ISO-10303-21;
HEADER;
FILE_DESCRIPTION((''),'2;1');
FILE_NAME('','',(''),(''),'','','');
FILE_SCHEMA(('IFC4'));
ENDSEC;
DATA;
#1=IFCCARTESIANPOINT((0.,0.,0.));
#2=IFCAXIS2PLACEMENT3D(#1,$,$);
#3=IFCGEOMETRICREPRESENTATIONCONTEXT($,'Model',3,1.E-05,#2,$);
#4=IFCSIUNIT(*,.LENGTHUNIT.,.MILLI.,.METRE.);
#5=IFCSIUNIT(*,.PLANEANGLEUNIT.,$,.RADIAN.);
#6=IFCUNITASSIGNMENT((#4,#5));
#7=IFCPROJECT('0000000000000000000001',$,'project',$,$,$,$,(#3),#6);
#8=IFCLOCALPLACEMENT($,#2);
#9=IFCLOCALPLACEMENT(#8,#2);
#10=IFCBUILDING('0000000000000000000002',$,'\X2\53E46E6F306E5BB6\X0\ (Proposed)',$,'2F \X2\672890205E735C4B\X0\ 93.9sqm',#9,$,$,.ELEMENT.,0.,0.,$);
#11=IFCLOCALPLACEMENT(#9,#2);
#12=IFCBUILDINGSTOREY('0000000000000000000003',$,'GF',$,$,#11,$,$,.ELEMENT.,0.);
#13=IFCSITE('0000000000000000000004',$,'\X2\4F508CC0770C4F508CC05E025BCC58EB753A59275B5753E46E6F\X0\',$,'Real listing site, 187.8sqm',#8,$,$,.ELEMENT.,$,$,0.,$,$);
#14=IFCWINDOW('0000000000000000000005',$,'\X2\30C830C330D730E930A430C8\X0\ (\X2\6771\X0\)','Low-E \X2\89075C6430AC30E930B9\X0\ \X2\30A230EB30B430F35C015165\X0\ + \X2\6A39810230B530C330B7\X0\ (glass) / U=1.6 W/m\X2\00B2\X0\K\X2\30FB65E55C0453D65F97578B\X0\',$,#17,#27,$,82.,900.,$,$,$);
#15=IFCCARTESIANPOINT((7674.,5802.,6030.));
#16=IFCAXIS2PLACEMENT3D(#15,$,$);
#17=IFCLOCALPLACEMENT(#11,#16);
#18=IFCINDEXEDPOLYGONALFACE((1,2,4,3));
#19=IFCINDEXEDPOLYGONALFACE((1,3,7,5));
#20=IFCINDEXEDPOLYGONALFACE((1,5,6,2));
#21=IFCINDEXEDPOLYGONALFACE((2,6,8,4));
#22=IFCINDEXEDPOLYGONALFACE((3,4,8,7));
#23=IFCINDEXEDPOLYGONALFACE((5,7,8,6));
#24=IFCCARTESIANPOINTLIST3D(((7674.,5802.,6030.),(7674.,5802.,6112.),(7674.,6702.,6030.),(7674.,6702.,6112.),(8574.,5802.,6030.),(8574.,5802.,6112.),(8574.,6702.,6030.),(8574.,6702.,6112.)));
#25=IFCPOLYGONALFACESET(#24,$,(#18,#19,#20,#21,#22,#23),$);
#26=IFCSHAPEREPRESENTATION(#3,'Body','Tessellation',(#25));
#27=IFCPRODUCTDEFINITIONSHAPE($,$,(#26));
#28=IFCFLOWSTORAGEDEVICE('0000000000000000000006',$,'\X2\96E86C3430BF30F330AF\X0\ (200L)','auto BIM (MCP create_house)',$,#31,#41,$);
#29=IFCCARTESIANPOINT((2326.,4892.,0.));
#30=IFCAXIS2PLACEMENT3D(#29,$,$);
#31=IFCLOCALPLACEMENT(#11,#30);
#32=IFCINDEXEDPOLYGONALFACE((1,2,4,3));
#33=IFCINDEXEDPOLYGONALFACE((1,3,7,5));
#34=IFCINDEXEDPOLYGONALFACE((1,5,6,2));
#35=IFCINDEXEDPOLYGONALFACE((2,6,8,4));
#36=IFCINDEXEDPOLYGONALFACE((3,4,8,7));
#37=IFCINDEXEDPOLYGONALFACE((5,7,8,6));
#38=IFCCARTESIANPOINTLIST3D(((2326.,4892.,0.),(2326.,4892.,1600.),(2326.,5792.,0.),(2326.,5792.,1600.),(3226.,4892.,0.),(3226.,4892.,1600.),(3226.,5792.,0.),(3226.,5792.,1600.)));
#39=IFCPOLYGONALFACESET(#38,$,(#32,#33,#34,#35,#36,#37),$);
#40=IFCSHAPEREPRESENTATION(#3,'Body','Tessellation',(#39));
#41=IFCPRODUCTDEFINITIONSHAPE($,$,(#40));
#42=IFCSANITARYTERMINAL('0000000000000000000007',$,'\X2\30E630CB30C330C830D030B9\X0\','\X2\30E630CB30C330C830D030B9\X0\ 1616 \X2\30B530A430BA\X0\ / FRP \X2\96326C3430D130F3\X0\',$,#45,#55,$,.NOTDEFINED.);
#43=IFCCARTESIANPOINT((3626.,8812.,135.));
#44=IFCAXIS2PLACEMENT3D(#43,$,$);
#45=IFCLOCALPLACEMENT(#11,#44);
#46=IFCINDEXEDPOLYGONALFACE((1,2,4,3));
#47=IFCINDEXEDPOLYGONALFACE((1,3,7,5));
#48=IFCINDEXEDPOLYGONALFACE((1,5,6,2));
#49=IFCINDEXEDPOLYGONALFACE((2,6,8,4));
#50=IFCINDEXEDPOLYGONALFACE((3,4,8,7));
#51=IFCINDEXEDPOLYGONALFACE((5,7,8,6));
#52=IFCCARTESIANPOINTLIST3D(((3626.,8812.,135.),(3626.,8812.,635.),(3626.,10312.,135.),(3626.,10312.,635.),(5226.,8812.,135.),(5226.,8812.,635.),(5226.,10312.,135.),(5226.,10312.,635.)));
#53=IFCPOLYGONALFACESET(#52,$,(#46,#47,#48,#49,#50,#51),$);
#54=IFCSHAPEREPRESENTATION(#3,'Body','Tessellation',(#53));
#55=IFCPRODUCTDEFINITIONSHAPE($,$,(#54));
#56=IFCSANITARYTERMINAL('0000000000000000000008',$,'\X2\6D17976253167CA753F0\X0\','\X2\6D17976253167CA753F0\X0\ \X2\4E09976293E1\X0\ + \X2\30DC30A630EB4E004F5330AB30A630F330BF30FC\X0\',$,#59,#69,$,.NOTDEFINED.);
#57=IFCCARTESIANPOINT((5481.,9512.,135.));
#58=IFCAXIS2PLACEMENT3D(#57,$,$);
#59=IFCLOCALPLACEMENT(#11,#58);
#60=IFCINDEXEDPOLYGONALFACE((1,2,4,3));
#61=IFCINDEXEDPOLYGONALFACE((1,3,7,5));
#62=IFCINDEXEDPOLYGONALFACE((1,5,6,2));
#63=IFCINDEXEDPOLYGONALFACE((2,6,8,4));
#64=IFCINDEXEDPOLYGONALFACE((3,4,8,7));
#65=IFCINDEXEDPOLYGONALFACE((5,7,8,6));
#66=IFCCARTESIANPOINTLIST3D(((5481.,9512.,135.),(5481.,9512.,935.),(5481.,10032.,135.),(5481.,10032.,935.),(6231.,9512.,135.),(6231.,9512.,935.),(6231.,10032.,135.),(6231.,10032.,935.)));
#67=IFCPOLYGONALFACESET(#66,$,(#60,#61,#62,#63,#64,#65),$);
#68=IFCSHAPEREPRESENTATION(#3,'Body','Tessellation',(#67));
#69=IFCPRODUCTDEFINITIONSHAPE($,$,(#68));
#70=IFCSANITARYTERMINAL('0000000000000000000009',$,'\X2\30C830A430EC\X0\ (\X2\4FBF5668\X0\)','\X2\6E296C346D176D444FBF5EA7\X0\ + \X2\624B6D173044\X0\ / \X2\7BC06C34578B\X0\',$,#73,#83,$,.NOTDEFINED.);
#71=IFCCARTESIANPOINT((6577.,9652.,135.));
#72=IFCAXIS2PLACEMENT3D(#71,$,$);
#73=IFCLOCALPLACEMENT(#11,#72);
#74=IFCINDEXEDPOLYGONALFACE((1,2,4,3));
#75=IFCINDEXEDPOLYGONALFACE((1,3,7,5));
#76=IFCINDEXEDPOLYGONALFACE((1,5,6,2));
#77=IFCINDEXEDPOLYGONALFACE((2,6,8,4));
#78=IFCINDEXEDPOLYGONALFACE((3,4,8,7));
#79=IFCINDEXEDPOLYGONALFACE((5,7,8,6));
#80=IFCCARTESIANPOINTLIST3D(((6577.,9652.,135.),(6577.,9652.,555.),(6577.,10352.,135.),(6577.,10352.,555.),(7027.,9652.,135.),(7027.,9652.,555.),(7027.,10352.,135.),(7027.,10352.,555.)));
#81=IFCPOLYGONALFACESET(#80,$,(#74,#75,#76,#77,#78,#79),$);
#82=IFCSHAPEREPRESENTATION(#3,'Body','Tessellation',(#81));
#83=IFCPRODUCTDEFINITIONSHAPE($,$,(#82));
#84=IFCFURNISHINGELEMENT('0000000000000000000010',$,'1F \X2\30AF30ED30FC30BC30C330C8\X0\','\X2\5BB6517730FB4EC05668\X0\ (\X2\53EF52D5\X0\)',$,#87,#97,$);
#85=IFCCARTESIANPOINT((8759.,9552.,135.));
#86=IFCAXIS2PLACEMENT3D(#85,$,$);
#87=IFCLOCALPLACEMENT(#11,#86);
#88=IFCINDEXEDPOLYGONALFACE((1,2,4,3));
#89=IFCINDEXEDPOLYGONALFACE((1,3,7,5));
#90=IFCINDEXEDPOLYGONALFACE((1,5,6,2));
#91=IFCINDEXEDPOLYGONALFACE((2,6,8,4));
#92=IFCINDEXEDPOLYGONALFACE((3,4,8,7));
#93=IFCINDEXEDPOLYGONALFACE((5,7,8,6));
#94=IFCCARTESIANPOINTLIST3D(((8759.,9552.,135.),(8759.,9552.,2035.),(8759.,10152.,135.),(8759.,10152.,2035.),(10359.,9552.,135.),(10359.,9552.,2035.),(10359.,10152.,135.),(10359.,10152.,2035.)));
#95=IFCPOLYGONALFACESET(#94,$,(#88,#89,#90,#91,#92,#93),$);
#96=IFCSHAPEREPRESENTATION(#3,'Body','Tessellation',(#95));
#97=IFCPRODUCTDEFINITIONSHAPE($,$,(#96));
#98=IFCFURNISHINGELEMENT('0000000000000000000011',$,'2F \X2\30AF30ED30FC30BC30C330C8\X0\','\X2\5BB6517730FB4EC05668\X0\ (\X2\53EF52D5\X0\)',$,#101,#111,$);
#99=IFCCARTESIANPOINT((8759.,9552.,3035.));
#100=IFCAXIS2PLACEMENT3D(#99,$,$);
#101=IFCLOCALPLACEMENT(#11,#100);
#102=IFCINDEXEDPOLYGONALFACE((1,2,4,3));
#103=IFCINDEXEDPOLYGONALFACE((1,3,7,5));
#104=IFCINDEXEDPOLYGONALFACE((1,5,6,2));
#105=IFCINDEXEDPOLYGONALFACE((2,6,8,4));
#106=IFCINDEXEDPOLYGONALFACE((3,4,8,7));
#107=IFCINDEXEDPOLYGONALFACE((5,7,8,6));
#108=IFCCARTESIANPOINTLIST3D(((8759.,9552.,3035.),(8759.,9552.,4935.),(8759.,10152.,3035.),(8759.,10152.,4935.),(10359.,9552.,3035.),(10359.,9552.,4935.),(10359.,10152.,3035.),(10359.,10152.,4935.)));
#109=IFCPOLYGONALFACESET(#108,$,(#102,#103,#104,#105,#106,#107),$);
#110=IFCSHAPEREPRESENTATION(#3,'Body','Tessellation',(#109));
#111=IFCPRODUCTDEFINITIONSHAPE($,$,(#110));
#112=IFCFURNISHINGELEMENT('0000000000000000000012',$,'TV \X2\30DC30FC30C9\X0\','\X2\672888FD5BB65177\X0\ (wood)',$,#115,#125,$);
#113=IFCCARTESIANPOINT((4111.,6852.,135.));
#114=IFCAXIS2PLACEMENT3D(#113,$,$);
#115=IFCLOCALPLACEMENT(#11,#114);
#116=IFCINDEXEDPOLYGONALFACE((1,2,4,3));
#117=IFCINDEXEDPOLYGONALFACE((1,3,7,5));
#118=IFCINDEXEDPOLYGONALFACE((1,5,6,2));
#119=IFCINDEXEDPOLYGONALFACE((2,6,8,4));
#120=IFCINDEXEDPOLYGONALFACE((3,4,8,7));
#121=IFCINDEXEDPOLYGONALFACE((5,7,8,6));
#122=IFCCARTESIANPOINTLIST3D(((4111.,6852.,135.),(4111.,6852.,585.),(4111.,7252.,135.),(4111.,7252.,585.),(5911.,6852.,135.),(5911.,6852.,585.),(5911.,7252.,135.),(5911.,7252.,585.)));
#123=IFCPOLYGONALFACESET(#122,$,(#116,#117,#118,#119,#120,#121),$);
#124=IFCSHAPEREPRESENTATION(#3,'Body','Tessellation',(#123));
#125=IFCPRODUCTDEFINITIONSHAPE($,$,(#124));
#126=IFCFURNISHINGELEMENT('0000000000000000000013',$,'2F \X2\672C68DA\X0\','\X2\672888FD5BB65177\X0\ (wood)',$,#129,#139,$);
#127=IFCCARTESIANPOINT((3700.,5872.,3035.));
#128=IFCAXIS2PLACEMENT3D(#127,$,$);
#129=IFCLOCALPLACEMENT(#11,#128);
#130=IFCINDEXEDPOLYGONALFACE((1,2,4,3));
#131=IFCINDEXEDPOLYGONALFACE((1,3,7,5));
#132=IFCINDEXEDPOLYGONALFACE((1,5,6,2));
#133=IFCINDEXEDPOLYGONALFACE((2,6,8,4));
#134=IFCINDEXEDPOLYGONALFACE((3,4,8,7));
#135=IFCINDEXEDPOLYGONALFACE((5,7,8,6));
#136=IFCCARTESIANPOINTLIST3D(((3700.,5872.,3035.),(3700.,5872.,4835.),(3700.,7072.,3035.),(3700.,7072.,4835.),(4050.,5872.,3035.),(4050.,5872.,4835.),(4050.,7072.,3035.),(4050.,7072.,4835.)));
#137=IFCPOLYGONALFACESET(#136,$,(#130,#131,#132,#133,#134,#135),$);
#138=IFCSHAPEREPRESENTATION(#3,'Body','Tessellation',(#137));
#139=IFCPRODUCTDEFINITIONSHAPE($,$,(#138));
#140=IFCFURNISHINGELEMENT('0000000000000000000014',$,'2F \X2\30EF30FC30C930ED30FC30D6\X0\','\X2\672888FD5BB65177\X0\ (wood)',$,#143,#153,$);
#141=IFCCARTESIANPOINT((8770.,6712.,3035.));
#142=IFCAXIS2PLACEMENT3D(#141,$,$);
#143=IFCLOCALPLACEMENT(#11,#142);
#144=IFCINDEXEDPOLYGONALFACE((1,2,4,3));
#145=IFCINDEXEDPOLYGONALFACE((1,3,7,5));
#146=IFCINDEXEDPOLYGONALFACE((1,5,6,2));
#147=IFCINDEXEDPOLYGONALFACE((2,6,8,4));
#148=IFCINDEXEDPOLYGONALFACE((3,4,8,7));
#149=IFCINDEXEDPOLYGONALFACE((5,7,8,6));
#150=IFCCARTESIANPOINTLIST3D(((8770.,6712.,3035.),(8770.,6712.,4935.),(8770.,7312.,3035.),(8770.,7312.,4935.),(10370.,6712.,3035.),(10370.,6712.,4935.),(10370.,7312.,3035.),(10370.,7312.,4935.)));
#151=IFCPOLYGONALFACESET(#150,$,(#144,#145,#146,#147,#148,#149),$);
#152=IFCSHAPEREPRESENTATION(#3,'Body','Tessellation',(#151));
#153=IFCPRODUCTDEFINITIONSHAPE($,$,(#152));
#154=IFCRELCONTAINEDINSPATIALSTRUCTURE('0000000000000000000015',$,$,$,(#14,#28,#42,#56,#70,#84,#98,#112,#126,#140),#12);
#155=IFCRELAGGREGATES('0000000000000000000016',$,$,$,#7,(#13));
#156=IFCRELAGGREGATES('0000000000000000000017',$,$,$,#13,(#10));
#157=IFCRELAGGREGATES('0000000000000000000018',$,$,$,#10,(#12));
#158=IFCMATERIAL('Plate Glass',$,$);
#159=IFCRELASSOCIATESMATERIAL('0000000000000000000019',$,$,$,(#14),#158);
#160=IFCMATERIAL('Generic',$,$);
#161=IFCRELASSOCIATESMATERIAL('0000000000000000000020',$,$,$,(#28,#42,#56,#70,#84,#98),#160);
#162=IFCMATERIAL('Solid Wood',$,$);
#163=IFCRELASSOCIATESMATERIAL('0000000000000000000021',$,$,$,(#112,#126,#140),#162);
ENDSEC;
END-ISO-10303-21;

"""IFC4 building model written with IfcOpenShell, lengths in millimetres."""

from ifc_helpers import new_model, si_unit, frame, frame_2d, origin, place, context, project, spatial, rectangle, extrude, material, element, save


model = new_model("IFC4")

# Units and contexts
model_context = context("Model", 3, precision=1e-05, world=origin())
ifc_project = project(units=[si_unit("LENGTHUNIT", "METRE", prefix="MILLI"), si_unit("PLANEANGLEUNIT", "RADIAN")], contexts=[model_context])

# Site, building, storey
site_placement = place(None, origin())
site = spatial("IfcSite", under=ifc_project, at=site_placement, Name="佐賀県佐賀市富士町大字古湯", ObjectType="Real listing site, 187.8sqm", CompositionType="ELEMENT", RefElevation=0.0)
building_placement = place(site_placement, origin())
building = spatial("IfcBuilding", under=site, at=building_placement, Name="古湯の家 (Proposed)", ObjectType="2F 木造平屋 93.9sqm", CompositionType="ELEMENT", ElevationOfRefHeight=0.0, ElevationOfTerrain=0.0)
storey_placement = place(building_placement, origin())
storey = spatial("IfcBuildingStorey", under=building, at=storey_placement, Name="GF", CompositionType="ELEMENT", Elevation=0.0)

# Shared definitions
ifc_material_1 = material(Name="Solid Wood")
ifc_material_2 = material(Name="Plate Glass")

# Window
window_1_placement = place(storey_placement, frame((7674.0, 5802.0, 6030.0)))
element("IfcWindow", 1, at=window_1_placement, inside=storey, material=ifc_material_2, Name="トップライト (東)", Description="Low-E 複層ガラス アルゴン封入 + 樹脂サッシ (glass) / U=1.6 W/m²K・日射取得型", OverallHeight=82.0, OverallWidth=900.0, context=model_context, shape_type="SweptSolid", body=[
    extrude(rectangle(XDim=900.0, YDim=900.0, at=frame_2d((450.0, 450.0))), frame((7674.0, 5802.0, 6030.0)), (0.0, 0.0, 1.0), 82.0),
])

# Flow storage device
ifc_material_3 = material(Name="Generic")
flow_storage_device_placement = place(storey_placement, frame((2326.0, 4892.0, 0.0)))
element("IfcFlowStorageDevice", 2, at=flow_storage_device_placement, inside=storey, material=ifc_material_3, Name="雨水タンク (200L)", Description="auto BIM (MCP create_house)", context=model_context, shape_type="SweptSolid", body=[
    extrude(rectangle(XDim=900.0, YDim=900.0, at=frame_2d((450.0, 450.0))), frame((2326.0, 4892.0, 0.0)), (0.0, 0.0, 1.0), 1600.0),
])

# Sanitary terminals
sanitary_terminal_1_placement = place(storey_placement, frame((3626.0, 8812.0, 135.0)))
element("IfcSanitaryTerminal", 3, at=sanitary_terminal_1_placement, inside=storey, material=ifc_material_3, Name="ユニットバス", Description="ユニットバス 1616 サイズ / FRP 防水パン", PredefinedType="NOTDEFINED", context=model_context, shape_type="SweptSolid", body=[
    extrude(rectangle(XDim=1600.0, YDim=1500.0, at=frame_2d((800.0, 750.0))), frame((3626.0, 8812.0, 135.0)), (0.0, 0.0, 1.0), 500.0),
])
sanitary_terminal_2_placement = place(storey_placement, frame((5481.0, 9512.0, 135.0)))
element("IfcSanitaryTerminal", 4, at=sanitary_terminal_2_placement, inside=storey, material=ifc_material_3, Name="洗面化粧台", Description="洗面化粧台 三面鏡 + ボウル一体カウンター", PredefinedType="NOTDEFINED", context=model_context, shape_type="SweptSolid", body=[
    extrude(rectangle(XDim=750.0, YDim=520.0, at=frame_2d((375.0, 260.0))), frame((5481.0, 9512.0, 135.0)), (0.0, 0.0, 1.0), 800.0),
])
sanitary_terminal_3_placement = place(storey_placement, frame((6577.0, 9652.0, 135.0)))
element("IfcSanitaryTerminal", 5, at=sanitary_terminal_3_placement, inside=storey, material=ifc_material_3, Name="トイレ (便器)", Description="温水洗浄便座 + 手洗い / 節水型", PredefinedType="NOTDEFINED", context=model_context, shape_type="SweptSolid", body=[
    extrude(rectangle(XDim=450.0, YDim=700.0, at=frame_2d((225.0, 350.0))), frame((6577.0, 9652.0, 135.0)), (0.0, 0.0, 1.0), 420.0),
])

# Furnishing elements
furnishing_1_placement = place(storey_placement, frame((8759.0, 9552.0, 135.0)))
element("IfcFurnishingElement", 6, at=furnishing_1_placement, inside=storey, material=ifc_material_3, Name="1F クローゼット", Description="家具・什器 (可動)", context=model_context, shape_type="SweptSolid", body=[
    extrude(rectangle(XDim=1600.0, YDim=600.0, at=frame_2d((800.0, 300.0))), frame((8759.0, 9552.0, 135.0)), (0.0, 0.0, 1.0), 1900.0),
])
furnishing_2_placement = place(storey_placement, frame((8759.0, 9552.0, 3035.0)))
element("IfcFurnishingElement", 7, at=furnishing_2_placement, inside=storey, material=ifc_material_3, Name="2F クローゼット", Description="家具・什器 (可動)", context=model_context, shape_type="SweptSolid", body=[
    extrude(rectangle(XDim=1600.0, YDim=600.0, at=frame_2d((800.0, 300.0))), frame((8759.0, 9552.0, 3035.0)), (0.0, 0.0, 1.0), 1900.0),
])
furnishing_3_placement = place(storey_placement, frame((4111.0, 6852.0, 135.0)))
element("IfcFurnishingElement", 8, at=furnishing_3_placement, inside=storey, material=ifc_material_1, Name="TV ボード", Description="木製家具 (wood)", context=model_context, shape_type="SweptSolid", body=[
    extrude(rectangle(XDim=1800.0, YDim=400.0, at=frame_2d((900.0, 200.0))), frame((4111.0, 6852.0, 135.0)), (0.0, 0.0, 1.0), 450.0),
])
furnishing_4_placement = place(storey_placement, frame((3700.0, 5872.0, 3035.0)))
element("IfcFurnishingElement", 9, at=furnishing_4_placement, inside=storey, material=ifc_material_1, Name="2F 本棚", Description="木製家具 (wood)", context=model_context, shape_type="SweptSolid", body=[
    extrude(rectangle(XDim=350.0, YDim=1200.0, at=frame_2d((175.0, 600.0))), frame((3700.0, 5872.0, 3035.0)), (0.0, 0.0, 1.0), 1800.0),
])
furnishing_5_placement = place(storey_placement, frame((8770.0, 6712.0, 3035.0)))
element("IfcFurnishingElement", 10, at=furnishing_5_placement, inside=storey, material=ifc_material_1, Name="2F ワードローブ", Description="木製家具 (wood)", context=model_context, shape_type="SweptSolid", body=[
    extrude(rectangle(XDim=1600.0, YDim=600.0, at=frame_2d((800.0, 300.0))), frame((8770.0, 6712.0, 3035.0)), (0.0, 0.0, 1.0), 1900.0),
])

save(model, "model.ifc")
